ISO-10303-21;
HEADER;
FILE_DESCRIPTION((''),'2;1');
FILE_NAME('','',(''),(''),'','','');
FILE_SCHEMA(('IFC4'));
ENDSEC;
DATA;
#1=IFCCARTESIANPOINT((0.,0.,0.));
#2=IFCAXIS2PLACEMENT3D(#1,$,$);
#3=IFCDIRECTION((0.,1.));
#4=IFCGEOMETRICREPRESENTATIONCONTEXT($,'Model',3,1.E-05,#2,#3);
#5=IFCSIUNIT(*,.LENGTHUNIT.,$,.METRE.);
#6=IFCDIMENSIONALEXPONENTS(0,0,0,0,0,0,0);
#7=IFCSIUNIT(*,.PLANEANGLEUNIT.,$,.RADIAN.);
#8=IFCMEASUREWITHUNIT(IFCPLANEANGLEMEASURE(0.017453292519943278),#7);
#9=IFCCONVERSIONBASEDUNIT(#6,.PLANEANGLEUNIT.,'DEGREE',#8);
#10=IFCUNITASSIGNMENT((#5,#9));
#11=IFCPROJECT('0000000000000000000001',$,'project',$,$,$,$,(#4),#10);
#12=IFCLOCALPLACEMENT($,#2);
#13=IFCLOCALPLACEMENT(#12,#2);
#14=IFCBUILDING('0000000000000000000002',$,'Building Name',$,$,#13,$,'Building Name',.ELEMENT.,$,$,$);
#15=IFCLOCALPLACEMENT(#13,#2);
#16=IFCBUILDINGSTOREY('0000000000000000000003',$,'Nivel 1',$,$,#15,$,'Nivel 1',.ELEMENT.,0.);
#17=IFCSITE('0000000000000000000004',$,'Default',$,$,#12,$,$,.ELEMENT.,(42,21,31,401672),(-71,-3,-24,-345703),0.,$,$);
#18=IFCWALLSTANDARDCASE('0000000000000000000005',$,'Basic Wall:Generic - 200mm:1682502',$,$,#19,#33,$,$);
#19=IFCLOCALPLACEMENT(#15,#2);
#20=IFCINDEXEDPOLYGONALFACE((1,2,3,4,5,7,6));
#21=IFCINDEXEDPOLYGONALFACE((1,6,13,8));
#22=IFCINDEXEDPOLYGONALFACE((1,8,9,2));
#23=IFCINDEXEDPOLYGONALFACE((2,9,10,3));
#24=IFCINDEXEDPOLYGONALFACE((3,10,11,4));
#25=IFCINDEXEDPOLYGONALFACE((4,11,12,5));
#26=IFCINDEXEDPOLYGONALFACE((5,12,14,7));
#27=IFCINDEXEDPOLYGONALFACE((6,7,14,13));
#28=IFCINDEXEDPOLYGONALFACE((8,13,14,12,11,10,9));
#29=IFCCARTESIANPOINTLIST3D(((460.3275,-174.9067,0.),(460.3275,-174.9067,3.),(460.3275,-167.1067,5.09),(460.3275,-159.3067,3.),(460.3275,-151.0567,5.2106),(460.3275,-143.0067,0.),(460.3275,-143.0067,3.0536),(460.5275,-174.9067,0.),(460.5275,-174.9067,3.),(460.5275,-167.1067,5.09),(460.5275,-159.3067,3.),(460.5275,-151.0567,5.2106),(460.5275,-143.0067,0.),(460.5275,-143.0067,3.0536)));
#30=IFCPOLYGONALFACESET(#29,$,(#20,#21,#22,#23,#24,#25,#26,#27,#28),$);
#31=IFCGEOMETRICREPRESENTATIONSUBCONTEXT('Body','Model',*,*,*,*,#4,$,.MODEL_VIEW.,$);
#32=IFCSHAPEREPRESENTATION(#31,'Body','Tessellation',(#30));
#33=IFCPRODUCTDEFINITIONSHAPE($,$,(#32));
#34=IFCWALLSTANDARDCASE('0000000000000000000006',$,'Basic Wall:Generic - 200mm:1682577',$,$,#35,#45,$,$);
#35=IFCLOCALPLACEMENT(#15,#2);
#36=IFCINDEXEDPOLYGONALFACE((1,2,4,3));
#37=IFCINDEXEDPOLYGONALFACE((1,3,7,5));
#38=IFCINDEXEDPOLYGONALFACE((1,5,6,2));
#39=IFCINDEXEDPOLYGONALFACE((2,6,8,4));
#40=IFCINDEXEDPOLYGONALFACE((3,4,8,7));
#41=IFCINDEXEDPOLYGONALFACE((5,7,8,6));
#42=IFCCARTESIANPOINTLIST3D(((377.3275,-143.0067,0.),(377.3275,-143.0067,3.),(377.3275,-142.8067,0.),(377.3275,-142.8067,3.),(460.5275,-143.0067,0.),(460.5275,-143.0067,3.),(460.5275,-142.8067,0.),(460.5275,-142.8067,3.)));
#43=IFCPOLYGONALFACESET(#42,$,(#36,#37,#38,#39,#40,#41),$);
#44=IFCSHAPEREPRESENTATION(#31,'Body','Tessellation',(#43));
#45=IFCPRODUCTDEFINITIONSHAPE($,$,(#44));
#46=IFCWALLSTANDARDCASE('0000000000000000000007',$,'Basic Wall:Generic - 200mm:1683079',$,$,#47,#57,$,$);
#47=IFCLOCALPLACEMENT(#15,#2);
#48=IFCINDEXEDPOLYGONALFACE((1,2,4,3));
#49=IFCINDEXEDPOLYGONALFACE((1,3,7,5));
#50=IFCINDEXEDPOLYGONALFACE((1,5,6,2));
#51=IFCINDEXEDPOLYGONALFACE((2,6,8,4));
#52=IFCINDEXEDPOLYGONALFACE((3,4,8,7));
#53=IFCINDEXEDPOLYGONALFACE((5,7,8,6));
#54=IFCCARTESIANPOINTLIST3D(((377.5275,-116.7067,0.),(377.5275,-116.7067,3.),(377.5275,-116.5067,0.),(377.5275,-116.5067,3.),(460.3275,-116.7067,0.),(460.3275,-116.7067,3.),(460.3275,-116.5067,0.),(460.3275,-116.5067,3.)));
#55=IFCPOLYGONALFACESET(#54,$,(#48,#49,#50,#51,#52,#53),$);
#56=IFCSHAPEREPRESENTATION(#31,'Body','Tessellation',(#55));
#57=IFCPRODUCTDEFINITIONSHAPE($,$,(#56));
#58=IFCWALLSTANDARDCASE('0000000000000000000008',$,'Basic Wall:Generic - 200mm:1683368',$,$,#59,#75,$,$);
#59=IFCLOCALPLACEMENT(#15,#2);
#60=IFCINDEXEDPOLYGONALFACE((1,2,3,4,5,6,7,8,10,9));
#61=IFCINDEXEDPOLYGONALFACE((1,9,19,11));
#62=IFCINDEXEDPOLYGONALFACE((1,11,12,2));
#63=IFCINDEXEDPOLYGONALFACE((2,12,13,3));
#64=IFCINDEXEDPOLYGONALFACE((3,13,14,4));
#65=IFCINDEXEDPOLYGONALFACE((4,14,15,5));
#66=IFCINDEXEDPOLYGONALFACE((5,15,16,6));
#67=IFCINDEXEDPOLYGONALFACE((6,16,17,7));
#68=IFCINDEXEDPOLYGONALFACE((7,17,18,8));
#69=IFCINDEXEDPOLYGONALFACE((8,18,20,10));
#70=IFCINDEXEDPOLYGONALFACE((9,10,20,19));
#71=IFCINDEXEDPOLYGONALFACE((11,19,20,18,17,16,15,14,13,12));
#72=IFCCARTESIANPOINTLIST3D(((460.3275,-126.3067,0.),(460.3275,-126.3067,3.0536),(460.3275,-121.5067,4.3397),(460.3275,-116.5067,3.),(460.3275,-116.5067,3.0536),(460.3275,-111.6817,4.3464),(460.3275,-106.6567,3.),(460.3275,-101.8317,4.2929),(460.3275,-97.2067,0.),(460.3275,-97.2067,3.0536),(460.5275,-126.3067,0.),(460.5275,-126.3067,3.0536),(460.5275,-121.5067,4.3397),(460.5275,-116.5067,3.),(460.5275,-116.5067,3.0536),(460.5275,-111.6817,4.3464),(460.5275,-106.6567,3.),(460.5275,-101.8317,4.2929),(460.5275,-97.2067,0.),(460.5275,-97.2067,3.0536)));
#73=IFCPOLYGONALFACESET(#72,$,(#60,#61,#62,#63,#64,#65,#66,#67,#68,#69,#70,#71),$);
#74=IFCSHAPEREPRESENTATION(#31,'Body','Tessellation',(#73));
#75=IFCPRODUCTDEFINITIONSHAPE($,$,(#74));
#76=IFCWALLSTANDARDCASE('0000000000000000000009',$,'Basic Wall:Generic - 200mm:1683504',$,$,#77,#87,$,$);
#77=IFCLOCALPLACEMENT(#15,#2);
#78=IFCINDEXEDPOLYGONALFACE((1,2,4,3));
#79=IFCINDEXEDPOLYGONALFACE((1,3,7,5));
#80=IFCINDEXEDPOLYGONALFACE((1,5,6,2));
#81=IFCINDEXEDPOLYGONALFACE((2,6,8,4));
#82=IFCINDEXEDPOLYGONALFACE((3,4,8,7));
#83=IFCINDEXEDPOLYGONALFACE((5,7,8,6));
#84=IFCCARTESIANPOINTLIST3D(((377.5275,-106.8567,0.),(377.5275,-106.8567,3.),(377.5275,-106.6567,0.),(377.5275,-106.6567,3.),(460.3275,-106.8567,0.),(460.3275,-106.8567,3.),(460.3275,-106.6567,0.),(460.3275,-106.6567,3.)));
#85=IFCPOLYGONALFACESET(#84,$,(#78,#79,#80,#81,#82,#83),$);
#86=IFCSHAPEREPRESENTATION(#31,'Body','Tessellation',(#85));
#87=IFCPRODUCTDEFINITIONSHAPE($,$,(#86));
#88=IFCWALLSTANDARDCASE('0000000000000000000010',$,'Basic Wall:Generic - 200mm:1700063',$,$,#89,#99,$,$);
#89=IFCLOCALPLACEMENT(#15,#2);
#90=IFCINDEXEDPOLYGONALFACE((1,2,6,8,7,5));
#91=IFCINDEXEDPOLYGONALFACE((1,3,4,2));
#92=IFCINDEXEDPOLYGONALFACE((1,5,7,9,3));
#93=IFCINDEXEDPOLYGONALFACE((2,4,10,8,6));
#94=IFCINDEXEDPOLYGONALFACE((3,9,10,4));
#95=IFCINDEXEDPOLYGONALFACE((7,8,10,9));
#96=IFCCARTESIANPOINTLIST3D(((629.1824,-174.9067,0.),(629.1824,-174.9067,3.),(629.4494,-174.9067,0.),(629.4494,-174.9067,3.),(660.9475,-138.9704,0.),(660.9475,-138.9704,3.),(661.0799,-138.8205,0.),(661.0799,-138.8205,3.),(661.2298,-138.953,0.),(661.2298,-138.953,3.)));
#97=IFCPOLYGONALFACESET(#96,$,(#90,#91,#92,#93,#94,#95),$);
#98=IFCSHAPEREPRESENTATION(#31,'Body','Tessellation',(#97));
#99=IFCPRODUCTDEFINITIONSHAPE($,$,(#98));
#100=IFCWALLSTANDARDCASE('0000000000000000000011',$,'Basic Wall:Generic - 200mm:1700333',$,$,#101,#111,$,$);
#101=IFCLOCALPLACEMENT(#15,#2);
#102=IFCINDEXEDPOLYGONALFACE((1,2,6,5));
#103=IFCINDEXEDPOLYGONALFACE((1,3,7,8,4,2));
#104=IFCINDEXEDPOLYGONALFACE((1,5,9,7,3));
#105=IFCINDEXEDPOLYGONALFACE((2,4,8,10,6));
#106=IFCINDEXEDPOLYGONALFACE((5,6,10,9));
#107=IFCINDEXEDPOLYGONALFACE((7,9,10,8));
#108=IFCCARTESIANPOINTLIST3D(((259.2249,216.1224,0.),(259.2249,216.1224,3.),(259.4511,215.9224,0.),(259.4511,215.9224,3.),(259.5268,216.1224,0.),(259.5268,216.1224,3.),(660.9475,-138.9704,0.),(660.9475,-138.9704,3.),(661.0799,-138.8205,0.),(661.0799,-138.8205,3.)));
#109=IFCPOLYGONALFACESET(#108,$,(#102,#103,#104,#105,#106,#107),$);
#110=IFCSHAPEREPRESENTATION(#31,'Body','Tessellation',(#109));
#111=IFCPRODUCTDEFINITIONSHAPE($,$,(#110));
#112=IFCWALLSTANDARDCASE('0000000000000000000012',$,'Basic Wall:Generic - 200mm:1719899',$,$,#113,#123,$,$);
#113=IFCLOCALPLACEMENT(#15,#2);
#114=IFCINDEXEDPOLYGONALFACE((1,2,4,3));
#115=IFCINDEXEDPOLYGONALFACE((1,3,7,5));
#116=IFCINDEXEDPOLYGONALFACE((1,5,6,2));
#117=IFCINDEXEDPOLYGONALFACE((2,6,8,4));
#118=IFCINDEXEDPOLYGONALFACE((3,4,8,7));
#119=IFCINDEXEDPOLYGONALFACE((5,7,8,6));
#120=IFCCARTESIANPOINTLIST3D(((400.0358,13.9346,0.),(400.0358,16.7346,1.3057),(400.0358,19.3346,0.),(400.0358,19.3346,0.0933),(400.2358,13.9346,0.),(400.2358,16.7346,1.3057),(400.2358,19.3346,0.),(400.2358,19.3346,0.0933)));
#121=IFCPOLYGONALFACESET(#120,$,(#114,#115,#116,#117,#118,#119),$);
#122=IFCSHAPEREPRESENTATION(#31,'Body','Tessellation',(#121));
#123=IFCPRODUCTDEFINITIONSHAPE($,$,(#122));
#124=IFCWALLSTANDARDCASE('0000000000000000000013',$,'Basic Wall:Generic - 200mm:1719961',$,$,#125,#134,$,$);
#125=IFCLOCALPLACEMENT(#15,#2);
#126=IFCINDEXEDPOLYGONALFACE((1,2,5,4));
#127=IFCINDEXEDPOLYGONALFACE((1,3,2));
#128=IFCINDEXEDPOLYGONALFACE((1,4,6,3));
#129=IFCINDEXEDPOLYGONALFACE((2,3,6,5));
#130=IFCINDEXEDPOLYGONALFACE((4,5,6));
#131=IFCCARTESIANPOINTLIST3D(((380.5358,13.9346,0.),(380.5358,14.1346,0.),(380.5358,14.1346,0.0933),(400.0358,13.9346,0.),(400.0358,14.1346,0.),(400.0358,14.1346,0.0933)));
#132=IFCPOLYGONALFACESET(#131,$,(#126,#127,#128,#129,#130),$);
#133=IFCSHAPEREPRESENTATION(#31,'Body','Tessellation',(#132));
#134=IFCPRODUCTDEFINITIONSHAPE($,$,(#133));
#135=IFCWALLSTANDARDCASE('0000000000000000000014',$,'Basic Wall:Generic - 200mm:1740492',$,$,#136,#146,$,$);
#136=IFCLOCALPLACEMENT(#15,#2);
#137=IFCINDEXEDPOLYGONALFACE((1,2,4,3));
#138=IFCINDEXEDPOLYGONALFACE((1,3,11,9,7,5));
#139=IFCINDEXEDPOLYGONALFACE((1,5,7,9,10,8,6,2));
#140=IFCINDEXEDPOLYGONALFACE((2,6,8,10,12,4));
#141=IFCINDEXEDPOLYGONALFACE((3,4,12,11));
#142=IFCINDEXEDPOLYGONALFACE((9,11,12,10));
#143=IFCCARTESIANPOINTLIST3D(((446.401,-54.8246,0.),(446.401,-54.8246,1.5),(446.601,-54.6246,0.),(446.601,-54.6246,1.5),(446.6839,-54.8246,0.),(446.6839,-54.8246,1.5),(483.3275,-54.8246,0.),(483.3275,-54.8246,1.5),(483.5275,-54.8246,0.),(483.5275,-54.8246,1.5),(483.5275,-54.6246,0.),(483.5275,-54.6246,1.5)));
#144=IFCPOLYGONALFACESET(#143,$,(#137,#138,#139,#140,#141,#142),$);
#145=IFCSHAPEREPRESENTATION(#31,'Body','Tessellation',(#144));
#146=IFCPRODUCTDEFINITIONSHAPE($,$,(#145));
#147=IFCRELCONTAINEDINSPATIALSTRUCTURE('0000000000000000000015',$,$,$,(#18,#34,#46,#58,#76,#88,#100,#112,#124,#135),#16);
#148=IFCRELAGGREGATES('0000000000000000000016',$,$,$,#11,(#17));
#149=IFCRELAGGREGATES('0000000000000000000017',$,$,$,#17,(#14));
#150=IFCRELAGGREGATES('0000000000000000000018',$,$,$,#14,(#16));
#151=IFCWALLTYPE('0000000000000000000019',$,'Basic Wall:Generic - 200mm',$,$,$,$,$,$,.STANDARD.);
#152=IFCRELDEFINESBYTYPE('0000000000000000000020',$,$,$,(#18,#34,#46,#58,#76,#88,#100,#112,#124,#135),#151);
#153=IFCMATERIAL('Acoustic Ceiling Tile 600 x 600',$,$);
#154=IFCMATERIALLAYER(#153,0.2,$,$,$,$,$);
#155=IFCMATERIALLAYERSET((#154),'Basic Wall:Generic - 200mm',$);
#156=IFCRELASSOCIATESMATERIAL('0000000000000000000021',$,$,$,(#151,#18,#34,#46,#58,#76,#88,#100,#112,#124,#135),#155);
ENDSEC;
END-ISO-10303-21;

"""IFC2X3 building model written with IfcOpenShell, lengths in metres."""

from ifc_helpers import new_model, entity, si_unit, converted_unit, direction, frame, frame_2d, origin, place, context, subcontext, project, spatial, polyline, rectangle, outline, extrude, clip, bounded_halfspace, material, layer, layer_set, layer_usage, type_object, element, save


model = new_model("IFC2X3")

# Units and contexts
model_context = context("Model", 3, precision=1e-05, world=origin(), true_north=direction((0.0, 1.0)))
body_context = subcontext(model_context, "Body", "Model", "MODEL_VIEW")
ifc_project = project(units=[si_unit("LENGTHUNIT", "METRE"), converted_unit("PLANEANGLEUNIT", "DEGREE", entity("IfcPlaneAngleMeasure", 0.017453292519943278), si_unit("PLANEANGLEUNIT", "RADIAN"), dimensions=[0, 0, 0, 0, 0, 0, 0])], contexts=[model_context])

# Site, building, storey
site_placement = place(None, origin())
site = spatial("IfcSite", under=ifc_project, at=site_placement, Name="Default", CompositionType="ELEMENT", RefLatitude=(42, 21, 31, 401672), RefLongitude=(-71, -3, -24, -345703), RefElevation=0.0)
building_placement = place(site_placement, origin())
building = spatial("IfcBuilding", under=site, at=building_placement, Name="Building Name", LongName="Building Name", CompositionType="ELEMENT")
storey_placement = place(building_placement, origin())
storey = spatial("IfcBuildingStorey", under=building, at=storey_placement, Name="Nivel 1", LongName="Nivel 1", CompositionType="ELEMENT", Elevation=0.0)

# Walls
ifc_material_1 = material(Name="Acoustic Ceiling Tile 600 x 600")
ifc_layer = layer(ifc_material_1, 0.2)
ifc_layer_set = layer_set([ifc_layer], Name="Basic Wall:Generic - 200mm")
wall_type_1 = type_object("IfcWallType", Name="Basic Wall:Generic - 200mm", PredefinedType="STANDARD", material=ifc_layer_set)
ifc_layer_usage_1 = layer_usage(ifc_layer_set, "AXIS2", "NEGATIVE", 0.1)
wall_1_placement = place(storey_placement, frame((460.4275, -143.0067, 0.0), z_axis=(0.0, 0.0, 1.0), x_axis=(0.0, -1.0, 0.0)))
element("IfcWallStandardCase", 1, at=wall_1_placement, inside=storey, type_object=wall_type_1, material=ifc_layer_usage_1, Name="Basic Wall:Generic - 200mm:1682502", context=body_context, shape_type="Clipping", body=[
    clip(clip(clip(clip(extrude(rectangle(XDim=31.9, YDim=0.2, at=frame_2d((15.95, 0.0), x_axis=(-1.0, 0.0))), origin(), (0.0, 0.0, 1.0), 5.2106), bounded_halfspace(frame((0.0, -0.1, 3.0536), z_axis=(-0.258819, 0.0, 0.965926), x_axis=(0.0, -1.0, 0.0)), False, frame((0.0, -0.1, 3.0536)), polyline([(0.0, 0.0), (8.05, 0.0), (8.05, 0.2), (0.0, 0.2), (0.0, 0.0)]))), bounded_halfspace(frame((24.1, -0.1, 5.09), z_axis=(0.258819, 0.0, 0.965926), x_axis=(0.0, 1.0, 0.0)), False, frame((24.1, -0.1, 5.09)), polyline([(0.0, 0.0), (7.8, 0.0), (7.8, 0.2), (0.0, 0.2), (0.0, 0.0)]))), bounded_halfspace(frame((8.05, -0.1, 5.2106), z_axis=(0.258819, 0.0, 0.965926), x_axis=(0.0, 1.0, 0.0)), False, frame((8.05, -0.1, 5.2106)), polyline([(0.0, 0.0), (8.25, 0.0), (8.25, 0.2), (0.0, 0.2), (0.0, 0.0)]))), bounded_halfspace(frame((16.3, -0.1, 3.0), z_axis=(-0.258819, 0.0, 0.965926), x_axis=(0.0, -1.0, 0.0)), False, frame((16.3, -0.1, 3.0)), polyline([(0.0, 0.0), (7.8, 0.0), (7.8, 0.2), (0.0, 0.2), (0.0, 0.0)]))),
])
ifc_layer_usage_2 = layer_usage(ifc_layer_set, "AXIS2", "NEGATIVE", 0.1)
wall_2_placement = place(storey_placement, frame((460.5275, -142.9067, 0.0), z_axis=(0.0, 0.0, 1.0), x_axis=(-1.0, 0.0, 0.0)))
element("IfcWallStandardCase", 2, at=wall_2_placement, inside=storey, type_object=wall_type_1, material=ifc_layer_usage_2, Name="Basic Wall:Generic - 200mm:1682577", context=body_context, shape_type="SweptSolid", body=[
    extrude(rectangle(XDim=83.2, YDim=0.2, at=frame_2d((41.6, 0.0), x_axis=(-1.0, 0.0))), origin(), (0.0, 0.0, 1.0), 3.0),
])
ifc_layer_usage_3 = layer_usage(ifc_layer_set, "AXIS2", "NEGATIVE", 0.1)
wall_3_placement = place(storey_placement, frame((460.3275, -116.6067, 0.0), z_axis=(0.0, 0.0, 1.0), x_axis=(-1.0, 0.0, 0.0)))
element("IfcWallStandardCase", 3, at=wall_3_placement, inside=storey, type_object=wall_type_1, material=ifc_layer_usage_3, Name="Basic Wall:Generic - 200mm:1683079", context=body_context, shape_type="SweptSolid", body=[
    extrude(rectangle(XDim=82.8, YDim=0.2, at=frame_2d((41.4, 0.0), x_axis=(-1.0, 0.0))), origin(), (0.0, 0.0, 1.0), 3.0),
])
ifc_layer_usage_4 = layer_usage(ifc_layer_set, "AXIS2", "NEGATIVE", 0.1)
wall_4_placement = place(storey_placement, frame((460.4275, -97.2067, 0.0), z_axis=(0.0, 0.0, 1.0), x_axis=(0.0, -1.0, 0.0)))
element("IfcWallStandardCase", 4, at=wall_4_placement, inside=storey, type_object=wall_type_1, material=ifc_layer_usage_4, Name="Basic Wall:Generic - 200mm:1683368", context=body_context, shape_type="Clipping", body=[
    clip(clip(clip(clip(clip(clip(extrude(rectangle(XDim=29.1, YDim=0.2, at=frame_2d((14.55, 0.0), x_axis=(-1.0, 0.0))), origin(), (0.0, 0.0, 1.0), 4.3464), bounded_halfspace(frame((0.0, -0.1, 3.0536), z_axis=(-0.258819, 0.0, 0.965926), x_axis=(0.0, -1.0, 0.0)), False, frame((0.0, -0.1, 3.0536)), polyline([(0.0, 0.0), (4.625, 0.0), (4.625, 0.2), (0.0, 0.2), (0.0, 0.0)]))), bounded_halfspace(frame((9.45, -0.1, 3.0), z_axis=(-0.258819, 0.0, 0.965926), x_axis=(0.0, -1.0, 0.0)), False, frame((9.45, -0.1, 3.0)), polyline([(0.0, 0.0), (5.025, 0.0), (5.025, 0.2), (0.0, 0.2), (0.0, 0.0)]))), bounded_halfspace(frame((24.3, 0.1, 4.3397), z_axis=(-0.258819, 0.0, 0.965926), x_axis=(0.0, -1.0, 0.0)), False, frame((24.3, 0.1, 4.3397)), polyline([(0.0, 0.0), (-5.0, 0.0), (-5.0, -0.2), (0.0, -0.2), (0.0, 0.0)]))), bounded_halfspace(frame((4.625, -0.1, 4.2929), z_axis=(0.258819, 0.0, 0.965926), x_axis=(0.0, 1.0, 0.0)), False, frame((4.625, -0.1, 4.2929)), polyline([(0.0, 0.0), (4.825, 0.0), (4.825, 0.2), (0.0, 0.2), (0.0, 0.0)]))), bounded_halfspace(frame((29.1, -0.1, 3.0536), z_axis=(0.258819, 0.0, 0.965926), x_axis=(0.0, 1.0, 0.0)), False, frame((29.1, -0.1, 3.0536)), polyline([(0.0, 0.0), (0.0, 0.2), (-4.8, 0.2), (-4.8, 0.0), (0.0, 0.0)]))), bounded_halfspace(frame((14.475, -0.1, 4.3464), z_axis=(0.258819, 0.0, 0.965926), x_axis=(0.0, 1.0, 0.0)), False, frame((14.475, -0.1, 4.3464)), polyline([(0.0, 0.0), (4.825, 0.0), (4.825, 0.2), (0.0, 0.2), (0.0, 0.0)]))),
])
ifc_layer_usage_5 = layer_usage(ifc_layer_set, "AXIS2", "NEGATIVE", 0.1)
wall_5_placement = place(storey_placement, frame((460.3275, -106.7567, 0.0), z_axis=(0.0, 0.0, 1.0), x_axis=(-1.0, 0.0, 0.0)))
element("IfcWallStandardCase", 5, at=wall_5_placement, inside=storey, type_object=wall_type_1, material=ifc_layer_usage_5, Name="Basic Wall:Generic - 200mm:1683504", context=body_context, shape_type="SweptSolid", body=[
    extrude(rectangle(XDim=82.8, YDim=0.2, at=frame_2d((41.4, 0.0), x_axis=(-1.0, 0.0))), origin(), (0.0, 0.0, 1.0), 3.0),
])
ifc_layer_usage_6 = layer_usage(ifc_layer_set, "AXIS2", "NEGATIVE", 0.1)
wall_6_placement = place(storey_placement, frame((629.2573, -174.973, 0.0), z_axis=(0.0, 0.0, 1.0), x_axis=(0.662284, 0.749253, 0.0)))
element("IfcWallStandardCase", 6, at=wall_6_placement, inside=storey, type_object=wall_type_1, material=ifc_layer_usage_6, Name="Basic Wall:Generic - 200mm:1700063", context=body_context, shape_type="SweptSolid", body=[
    extrude(outline(polyline([(48.1629, -0.1), (48.1629, 0.1), (47.9629, 0.1), (0.0, 0.1), (0.1768, -0.1), (48.1629, -0.1)])), origin(), (0.0, 0.0, 1.0), 3.0),
])
ifc_layer_usage_7 = layer_usage(ifc_layer_set, "AXIS2", "NEGATIVE", 0.1)
wall_7_placement = place(storey_placement, frame((661.0137, -138.8955, 0.0), z_axis=(0.0, 0.0, 1.0), x_axis=(-0.749253, 0.662284, 0.0)))
element("IfcWallStandardCase", 7, at=wall_7_placement, inside=storey, type_object=wall_type_1, material=ifc_layer_usage_7, Name="Basic Wall:Generic - 200mm:1700333", context=body_context, shape_type="SweptSolid", body=[
    extrude(outline(polyline([(535.9379, -0.1), (536.1641, 0.1), (535.8621, 0.1), (0.0, 0.1), (0.0, -0.1), (535.9379, -0.1)])), origin(), (0.0, 0.0, 1.0), 3.0),
])
ifc_layer_usage_8 = layer_usage(ifc_layer_set, "AXIS2", "NEGATIVE", 0.1)
wall_8_placement = place(storey_placement, frame((400.1358, 19.3346, 0.0), z_axis=(0.0, 0.0, 1.0), x_axis=(0.0, -1.0, 0.0)))
element("IfcWallStandardCase", 8, at=wall_8_placement, inside=storey, type_object=wall_type_1, material=ifc_layer_usage_8, Name="Basic Wall:Generic - 200mm:1719899", context=body_context, shape_type="Clipping", body=[
    clip(clip(extrude(rectangle(XDim=5.4, YDim=0.2, at=frame_2d((2.7, 0.0), x_axis=(-1.0, 0.0))), origin(), (0.0, 0.0, 1.0), 1.3057), bounded_halfspace(frame((0.0, -0.1, 0.0933), z_axis=(-0.422618, 0.0, 0.906308), x_axis=(0.0, -1.0, 0.0)), False, frame((0.0, -0.1, 0.0933)), polyline([(0.0, 0.0), (2.6, 0.0), (2.6, 0.2), (0.0, 0.2), (0.0, 0.0)]))), bounded_halfspace(frame((2.6, -0.1, 1.3057), z_axis=(0.422618, 0.0, 0.906308), x_axis=(0.0, 1.0, 0.0)), False, frame((2.6, -0.1, 1.3057)), polyline([(0.0, 0.0), (2.6, 0.0), (2.8, 0.0), (2.8, 0.2), (0.0, 0.2), (0.0, 0.0)]))),
])
ifc_layer_usage_9 = layer_usage(ifc_layer_set, "AXIS2", "NEGATIVE", 0.1)
wall_9_placement = place(storey_placement, frame((400.0358, 14.0346, 0.0), z_axis=(0.0, 0.0, 1.0), x_axis=(-1.0, 0.0, 0.0)))
element("IfcWallStandardCase", 9, at=wall_9_placement, inside=storey, type_object=wall_type_1, material=ifc_layer_usage_9, Name="Basic Wall:Generic - 200mm:1719961", context=body_context, shape_type="Clipping", body=[
    clip(extrude(rectangle(XDim=19.5, YDim=0.2, at=frame_2d((9.75, 0.0), x_axis=(-1.0, 0.0))), origin(), (0.0, 0.0, 1.0), 0.0933), bounded_halfspace(frame((0.0, -0.1, 0.0933), z_axis=(0.0, 0.422618, 0.906308), x_axis=(-1.0, 0.0, 0.0)), False, frame((0.0, -0.1, 0.0933)), polyline([(0.0, 0.0), (19.3, 0.0), (19.5, 0.0), (19.5, 0.2), (0.0, 0.2), (0.0, 0.0)]))),
])
ifc_layer_usage_10 = layer_usage(ifc_layer_set, "AXIS2", "NEGATIVE", 0.1)
wall_10_placement = place(storey_placement, frame((446.401, -54.7246, 0.0)))
element("IfcWallStandardCase", 10, at=wall_10_placement, inside=storey, type_object=wall_type_1, material=ifc_layer_usage_10, Name="Basic Wall:Generic - 200mm:1740492", context=body_context, shape_type="SweptSolid", body=[
    extrude(outline(polyline([(37.1265, -0.1), (37.1265, 0.1), (0.2, 0.1), (0.0, -0.1), (0.2828, -0.1), (36.9265, -0.1), (37.1265, -0.1)])), origin(), (0.0, 0.0, 1.0), 1.5),
])

save(model, "model.ifc")
